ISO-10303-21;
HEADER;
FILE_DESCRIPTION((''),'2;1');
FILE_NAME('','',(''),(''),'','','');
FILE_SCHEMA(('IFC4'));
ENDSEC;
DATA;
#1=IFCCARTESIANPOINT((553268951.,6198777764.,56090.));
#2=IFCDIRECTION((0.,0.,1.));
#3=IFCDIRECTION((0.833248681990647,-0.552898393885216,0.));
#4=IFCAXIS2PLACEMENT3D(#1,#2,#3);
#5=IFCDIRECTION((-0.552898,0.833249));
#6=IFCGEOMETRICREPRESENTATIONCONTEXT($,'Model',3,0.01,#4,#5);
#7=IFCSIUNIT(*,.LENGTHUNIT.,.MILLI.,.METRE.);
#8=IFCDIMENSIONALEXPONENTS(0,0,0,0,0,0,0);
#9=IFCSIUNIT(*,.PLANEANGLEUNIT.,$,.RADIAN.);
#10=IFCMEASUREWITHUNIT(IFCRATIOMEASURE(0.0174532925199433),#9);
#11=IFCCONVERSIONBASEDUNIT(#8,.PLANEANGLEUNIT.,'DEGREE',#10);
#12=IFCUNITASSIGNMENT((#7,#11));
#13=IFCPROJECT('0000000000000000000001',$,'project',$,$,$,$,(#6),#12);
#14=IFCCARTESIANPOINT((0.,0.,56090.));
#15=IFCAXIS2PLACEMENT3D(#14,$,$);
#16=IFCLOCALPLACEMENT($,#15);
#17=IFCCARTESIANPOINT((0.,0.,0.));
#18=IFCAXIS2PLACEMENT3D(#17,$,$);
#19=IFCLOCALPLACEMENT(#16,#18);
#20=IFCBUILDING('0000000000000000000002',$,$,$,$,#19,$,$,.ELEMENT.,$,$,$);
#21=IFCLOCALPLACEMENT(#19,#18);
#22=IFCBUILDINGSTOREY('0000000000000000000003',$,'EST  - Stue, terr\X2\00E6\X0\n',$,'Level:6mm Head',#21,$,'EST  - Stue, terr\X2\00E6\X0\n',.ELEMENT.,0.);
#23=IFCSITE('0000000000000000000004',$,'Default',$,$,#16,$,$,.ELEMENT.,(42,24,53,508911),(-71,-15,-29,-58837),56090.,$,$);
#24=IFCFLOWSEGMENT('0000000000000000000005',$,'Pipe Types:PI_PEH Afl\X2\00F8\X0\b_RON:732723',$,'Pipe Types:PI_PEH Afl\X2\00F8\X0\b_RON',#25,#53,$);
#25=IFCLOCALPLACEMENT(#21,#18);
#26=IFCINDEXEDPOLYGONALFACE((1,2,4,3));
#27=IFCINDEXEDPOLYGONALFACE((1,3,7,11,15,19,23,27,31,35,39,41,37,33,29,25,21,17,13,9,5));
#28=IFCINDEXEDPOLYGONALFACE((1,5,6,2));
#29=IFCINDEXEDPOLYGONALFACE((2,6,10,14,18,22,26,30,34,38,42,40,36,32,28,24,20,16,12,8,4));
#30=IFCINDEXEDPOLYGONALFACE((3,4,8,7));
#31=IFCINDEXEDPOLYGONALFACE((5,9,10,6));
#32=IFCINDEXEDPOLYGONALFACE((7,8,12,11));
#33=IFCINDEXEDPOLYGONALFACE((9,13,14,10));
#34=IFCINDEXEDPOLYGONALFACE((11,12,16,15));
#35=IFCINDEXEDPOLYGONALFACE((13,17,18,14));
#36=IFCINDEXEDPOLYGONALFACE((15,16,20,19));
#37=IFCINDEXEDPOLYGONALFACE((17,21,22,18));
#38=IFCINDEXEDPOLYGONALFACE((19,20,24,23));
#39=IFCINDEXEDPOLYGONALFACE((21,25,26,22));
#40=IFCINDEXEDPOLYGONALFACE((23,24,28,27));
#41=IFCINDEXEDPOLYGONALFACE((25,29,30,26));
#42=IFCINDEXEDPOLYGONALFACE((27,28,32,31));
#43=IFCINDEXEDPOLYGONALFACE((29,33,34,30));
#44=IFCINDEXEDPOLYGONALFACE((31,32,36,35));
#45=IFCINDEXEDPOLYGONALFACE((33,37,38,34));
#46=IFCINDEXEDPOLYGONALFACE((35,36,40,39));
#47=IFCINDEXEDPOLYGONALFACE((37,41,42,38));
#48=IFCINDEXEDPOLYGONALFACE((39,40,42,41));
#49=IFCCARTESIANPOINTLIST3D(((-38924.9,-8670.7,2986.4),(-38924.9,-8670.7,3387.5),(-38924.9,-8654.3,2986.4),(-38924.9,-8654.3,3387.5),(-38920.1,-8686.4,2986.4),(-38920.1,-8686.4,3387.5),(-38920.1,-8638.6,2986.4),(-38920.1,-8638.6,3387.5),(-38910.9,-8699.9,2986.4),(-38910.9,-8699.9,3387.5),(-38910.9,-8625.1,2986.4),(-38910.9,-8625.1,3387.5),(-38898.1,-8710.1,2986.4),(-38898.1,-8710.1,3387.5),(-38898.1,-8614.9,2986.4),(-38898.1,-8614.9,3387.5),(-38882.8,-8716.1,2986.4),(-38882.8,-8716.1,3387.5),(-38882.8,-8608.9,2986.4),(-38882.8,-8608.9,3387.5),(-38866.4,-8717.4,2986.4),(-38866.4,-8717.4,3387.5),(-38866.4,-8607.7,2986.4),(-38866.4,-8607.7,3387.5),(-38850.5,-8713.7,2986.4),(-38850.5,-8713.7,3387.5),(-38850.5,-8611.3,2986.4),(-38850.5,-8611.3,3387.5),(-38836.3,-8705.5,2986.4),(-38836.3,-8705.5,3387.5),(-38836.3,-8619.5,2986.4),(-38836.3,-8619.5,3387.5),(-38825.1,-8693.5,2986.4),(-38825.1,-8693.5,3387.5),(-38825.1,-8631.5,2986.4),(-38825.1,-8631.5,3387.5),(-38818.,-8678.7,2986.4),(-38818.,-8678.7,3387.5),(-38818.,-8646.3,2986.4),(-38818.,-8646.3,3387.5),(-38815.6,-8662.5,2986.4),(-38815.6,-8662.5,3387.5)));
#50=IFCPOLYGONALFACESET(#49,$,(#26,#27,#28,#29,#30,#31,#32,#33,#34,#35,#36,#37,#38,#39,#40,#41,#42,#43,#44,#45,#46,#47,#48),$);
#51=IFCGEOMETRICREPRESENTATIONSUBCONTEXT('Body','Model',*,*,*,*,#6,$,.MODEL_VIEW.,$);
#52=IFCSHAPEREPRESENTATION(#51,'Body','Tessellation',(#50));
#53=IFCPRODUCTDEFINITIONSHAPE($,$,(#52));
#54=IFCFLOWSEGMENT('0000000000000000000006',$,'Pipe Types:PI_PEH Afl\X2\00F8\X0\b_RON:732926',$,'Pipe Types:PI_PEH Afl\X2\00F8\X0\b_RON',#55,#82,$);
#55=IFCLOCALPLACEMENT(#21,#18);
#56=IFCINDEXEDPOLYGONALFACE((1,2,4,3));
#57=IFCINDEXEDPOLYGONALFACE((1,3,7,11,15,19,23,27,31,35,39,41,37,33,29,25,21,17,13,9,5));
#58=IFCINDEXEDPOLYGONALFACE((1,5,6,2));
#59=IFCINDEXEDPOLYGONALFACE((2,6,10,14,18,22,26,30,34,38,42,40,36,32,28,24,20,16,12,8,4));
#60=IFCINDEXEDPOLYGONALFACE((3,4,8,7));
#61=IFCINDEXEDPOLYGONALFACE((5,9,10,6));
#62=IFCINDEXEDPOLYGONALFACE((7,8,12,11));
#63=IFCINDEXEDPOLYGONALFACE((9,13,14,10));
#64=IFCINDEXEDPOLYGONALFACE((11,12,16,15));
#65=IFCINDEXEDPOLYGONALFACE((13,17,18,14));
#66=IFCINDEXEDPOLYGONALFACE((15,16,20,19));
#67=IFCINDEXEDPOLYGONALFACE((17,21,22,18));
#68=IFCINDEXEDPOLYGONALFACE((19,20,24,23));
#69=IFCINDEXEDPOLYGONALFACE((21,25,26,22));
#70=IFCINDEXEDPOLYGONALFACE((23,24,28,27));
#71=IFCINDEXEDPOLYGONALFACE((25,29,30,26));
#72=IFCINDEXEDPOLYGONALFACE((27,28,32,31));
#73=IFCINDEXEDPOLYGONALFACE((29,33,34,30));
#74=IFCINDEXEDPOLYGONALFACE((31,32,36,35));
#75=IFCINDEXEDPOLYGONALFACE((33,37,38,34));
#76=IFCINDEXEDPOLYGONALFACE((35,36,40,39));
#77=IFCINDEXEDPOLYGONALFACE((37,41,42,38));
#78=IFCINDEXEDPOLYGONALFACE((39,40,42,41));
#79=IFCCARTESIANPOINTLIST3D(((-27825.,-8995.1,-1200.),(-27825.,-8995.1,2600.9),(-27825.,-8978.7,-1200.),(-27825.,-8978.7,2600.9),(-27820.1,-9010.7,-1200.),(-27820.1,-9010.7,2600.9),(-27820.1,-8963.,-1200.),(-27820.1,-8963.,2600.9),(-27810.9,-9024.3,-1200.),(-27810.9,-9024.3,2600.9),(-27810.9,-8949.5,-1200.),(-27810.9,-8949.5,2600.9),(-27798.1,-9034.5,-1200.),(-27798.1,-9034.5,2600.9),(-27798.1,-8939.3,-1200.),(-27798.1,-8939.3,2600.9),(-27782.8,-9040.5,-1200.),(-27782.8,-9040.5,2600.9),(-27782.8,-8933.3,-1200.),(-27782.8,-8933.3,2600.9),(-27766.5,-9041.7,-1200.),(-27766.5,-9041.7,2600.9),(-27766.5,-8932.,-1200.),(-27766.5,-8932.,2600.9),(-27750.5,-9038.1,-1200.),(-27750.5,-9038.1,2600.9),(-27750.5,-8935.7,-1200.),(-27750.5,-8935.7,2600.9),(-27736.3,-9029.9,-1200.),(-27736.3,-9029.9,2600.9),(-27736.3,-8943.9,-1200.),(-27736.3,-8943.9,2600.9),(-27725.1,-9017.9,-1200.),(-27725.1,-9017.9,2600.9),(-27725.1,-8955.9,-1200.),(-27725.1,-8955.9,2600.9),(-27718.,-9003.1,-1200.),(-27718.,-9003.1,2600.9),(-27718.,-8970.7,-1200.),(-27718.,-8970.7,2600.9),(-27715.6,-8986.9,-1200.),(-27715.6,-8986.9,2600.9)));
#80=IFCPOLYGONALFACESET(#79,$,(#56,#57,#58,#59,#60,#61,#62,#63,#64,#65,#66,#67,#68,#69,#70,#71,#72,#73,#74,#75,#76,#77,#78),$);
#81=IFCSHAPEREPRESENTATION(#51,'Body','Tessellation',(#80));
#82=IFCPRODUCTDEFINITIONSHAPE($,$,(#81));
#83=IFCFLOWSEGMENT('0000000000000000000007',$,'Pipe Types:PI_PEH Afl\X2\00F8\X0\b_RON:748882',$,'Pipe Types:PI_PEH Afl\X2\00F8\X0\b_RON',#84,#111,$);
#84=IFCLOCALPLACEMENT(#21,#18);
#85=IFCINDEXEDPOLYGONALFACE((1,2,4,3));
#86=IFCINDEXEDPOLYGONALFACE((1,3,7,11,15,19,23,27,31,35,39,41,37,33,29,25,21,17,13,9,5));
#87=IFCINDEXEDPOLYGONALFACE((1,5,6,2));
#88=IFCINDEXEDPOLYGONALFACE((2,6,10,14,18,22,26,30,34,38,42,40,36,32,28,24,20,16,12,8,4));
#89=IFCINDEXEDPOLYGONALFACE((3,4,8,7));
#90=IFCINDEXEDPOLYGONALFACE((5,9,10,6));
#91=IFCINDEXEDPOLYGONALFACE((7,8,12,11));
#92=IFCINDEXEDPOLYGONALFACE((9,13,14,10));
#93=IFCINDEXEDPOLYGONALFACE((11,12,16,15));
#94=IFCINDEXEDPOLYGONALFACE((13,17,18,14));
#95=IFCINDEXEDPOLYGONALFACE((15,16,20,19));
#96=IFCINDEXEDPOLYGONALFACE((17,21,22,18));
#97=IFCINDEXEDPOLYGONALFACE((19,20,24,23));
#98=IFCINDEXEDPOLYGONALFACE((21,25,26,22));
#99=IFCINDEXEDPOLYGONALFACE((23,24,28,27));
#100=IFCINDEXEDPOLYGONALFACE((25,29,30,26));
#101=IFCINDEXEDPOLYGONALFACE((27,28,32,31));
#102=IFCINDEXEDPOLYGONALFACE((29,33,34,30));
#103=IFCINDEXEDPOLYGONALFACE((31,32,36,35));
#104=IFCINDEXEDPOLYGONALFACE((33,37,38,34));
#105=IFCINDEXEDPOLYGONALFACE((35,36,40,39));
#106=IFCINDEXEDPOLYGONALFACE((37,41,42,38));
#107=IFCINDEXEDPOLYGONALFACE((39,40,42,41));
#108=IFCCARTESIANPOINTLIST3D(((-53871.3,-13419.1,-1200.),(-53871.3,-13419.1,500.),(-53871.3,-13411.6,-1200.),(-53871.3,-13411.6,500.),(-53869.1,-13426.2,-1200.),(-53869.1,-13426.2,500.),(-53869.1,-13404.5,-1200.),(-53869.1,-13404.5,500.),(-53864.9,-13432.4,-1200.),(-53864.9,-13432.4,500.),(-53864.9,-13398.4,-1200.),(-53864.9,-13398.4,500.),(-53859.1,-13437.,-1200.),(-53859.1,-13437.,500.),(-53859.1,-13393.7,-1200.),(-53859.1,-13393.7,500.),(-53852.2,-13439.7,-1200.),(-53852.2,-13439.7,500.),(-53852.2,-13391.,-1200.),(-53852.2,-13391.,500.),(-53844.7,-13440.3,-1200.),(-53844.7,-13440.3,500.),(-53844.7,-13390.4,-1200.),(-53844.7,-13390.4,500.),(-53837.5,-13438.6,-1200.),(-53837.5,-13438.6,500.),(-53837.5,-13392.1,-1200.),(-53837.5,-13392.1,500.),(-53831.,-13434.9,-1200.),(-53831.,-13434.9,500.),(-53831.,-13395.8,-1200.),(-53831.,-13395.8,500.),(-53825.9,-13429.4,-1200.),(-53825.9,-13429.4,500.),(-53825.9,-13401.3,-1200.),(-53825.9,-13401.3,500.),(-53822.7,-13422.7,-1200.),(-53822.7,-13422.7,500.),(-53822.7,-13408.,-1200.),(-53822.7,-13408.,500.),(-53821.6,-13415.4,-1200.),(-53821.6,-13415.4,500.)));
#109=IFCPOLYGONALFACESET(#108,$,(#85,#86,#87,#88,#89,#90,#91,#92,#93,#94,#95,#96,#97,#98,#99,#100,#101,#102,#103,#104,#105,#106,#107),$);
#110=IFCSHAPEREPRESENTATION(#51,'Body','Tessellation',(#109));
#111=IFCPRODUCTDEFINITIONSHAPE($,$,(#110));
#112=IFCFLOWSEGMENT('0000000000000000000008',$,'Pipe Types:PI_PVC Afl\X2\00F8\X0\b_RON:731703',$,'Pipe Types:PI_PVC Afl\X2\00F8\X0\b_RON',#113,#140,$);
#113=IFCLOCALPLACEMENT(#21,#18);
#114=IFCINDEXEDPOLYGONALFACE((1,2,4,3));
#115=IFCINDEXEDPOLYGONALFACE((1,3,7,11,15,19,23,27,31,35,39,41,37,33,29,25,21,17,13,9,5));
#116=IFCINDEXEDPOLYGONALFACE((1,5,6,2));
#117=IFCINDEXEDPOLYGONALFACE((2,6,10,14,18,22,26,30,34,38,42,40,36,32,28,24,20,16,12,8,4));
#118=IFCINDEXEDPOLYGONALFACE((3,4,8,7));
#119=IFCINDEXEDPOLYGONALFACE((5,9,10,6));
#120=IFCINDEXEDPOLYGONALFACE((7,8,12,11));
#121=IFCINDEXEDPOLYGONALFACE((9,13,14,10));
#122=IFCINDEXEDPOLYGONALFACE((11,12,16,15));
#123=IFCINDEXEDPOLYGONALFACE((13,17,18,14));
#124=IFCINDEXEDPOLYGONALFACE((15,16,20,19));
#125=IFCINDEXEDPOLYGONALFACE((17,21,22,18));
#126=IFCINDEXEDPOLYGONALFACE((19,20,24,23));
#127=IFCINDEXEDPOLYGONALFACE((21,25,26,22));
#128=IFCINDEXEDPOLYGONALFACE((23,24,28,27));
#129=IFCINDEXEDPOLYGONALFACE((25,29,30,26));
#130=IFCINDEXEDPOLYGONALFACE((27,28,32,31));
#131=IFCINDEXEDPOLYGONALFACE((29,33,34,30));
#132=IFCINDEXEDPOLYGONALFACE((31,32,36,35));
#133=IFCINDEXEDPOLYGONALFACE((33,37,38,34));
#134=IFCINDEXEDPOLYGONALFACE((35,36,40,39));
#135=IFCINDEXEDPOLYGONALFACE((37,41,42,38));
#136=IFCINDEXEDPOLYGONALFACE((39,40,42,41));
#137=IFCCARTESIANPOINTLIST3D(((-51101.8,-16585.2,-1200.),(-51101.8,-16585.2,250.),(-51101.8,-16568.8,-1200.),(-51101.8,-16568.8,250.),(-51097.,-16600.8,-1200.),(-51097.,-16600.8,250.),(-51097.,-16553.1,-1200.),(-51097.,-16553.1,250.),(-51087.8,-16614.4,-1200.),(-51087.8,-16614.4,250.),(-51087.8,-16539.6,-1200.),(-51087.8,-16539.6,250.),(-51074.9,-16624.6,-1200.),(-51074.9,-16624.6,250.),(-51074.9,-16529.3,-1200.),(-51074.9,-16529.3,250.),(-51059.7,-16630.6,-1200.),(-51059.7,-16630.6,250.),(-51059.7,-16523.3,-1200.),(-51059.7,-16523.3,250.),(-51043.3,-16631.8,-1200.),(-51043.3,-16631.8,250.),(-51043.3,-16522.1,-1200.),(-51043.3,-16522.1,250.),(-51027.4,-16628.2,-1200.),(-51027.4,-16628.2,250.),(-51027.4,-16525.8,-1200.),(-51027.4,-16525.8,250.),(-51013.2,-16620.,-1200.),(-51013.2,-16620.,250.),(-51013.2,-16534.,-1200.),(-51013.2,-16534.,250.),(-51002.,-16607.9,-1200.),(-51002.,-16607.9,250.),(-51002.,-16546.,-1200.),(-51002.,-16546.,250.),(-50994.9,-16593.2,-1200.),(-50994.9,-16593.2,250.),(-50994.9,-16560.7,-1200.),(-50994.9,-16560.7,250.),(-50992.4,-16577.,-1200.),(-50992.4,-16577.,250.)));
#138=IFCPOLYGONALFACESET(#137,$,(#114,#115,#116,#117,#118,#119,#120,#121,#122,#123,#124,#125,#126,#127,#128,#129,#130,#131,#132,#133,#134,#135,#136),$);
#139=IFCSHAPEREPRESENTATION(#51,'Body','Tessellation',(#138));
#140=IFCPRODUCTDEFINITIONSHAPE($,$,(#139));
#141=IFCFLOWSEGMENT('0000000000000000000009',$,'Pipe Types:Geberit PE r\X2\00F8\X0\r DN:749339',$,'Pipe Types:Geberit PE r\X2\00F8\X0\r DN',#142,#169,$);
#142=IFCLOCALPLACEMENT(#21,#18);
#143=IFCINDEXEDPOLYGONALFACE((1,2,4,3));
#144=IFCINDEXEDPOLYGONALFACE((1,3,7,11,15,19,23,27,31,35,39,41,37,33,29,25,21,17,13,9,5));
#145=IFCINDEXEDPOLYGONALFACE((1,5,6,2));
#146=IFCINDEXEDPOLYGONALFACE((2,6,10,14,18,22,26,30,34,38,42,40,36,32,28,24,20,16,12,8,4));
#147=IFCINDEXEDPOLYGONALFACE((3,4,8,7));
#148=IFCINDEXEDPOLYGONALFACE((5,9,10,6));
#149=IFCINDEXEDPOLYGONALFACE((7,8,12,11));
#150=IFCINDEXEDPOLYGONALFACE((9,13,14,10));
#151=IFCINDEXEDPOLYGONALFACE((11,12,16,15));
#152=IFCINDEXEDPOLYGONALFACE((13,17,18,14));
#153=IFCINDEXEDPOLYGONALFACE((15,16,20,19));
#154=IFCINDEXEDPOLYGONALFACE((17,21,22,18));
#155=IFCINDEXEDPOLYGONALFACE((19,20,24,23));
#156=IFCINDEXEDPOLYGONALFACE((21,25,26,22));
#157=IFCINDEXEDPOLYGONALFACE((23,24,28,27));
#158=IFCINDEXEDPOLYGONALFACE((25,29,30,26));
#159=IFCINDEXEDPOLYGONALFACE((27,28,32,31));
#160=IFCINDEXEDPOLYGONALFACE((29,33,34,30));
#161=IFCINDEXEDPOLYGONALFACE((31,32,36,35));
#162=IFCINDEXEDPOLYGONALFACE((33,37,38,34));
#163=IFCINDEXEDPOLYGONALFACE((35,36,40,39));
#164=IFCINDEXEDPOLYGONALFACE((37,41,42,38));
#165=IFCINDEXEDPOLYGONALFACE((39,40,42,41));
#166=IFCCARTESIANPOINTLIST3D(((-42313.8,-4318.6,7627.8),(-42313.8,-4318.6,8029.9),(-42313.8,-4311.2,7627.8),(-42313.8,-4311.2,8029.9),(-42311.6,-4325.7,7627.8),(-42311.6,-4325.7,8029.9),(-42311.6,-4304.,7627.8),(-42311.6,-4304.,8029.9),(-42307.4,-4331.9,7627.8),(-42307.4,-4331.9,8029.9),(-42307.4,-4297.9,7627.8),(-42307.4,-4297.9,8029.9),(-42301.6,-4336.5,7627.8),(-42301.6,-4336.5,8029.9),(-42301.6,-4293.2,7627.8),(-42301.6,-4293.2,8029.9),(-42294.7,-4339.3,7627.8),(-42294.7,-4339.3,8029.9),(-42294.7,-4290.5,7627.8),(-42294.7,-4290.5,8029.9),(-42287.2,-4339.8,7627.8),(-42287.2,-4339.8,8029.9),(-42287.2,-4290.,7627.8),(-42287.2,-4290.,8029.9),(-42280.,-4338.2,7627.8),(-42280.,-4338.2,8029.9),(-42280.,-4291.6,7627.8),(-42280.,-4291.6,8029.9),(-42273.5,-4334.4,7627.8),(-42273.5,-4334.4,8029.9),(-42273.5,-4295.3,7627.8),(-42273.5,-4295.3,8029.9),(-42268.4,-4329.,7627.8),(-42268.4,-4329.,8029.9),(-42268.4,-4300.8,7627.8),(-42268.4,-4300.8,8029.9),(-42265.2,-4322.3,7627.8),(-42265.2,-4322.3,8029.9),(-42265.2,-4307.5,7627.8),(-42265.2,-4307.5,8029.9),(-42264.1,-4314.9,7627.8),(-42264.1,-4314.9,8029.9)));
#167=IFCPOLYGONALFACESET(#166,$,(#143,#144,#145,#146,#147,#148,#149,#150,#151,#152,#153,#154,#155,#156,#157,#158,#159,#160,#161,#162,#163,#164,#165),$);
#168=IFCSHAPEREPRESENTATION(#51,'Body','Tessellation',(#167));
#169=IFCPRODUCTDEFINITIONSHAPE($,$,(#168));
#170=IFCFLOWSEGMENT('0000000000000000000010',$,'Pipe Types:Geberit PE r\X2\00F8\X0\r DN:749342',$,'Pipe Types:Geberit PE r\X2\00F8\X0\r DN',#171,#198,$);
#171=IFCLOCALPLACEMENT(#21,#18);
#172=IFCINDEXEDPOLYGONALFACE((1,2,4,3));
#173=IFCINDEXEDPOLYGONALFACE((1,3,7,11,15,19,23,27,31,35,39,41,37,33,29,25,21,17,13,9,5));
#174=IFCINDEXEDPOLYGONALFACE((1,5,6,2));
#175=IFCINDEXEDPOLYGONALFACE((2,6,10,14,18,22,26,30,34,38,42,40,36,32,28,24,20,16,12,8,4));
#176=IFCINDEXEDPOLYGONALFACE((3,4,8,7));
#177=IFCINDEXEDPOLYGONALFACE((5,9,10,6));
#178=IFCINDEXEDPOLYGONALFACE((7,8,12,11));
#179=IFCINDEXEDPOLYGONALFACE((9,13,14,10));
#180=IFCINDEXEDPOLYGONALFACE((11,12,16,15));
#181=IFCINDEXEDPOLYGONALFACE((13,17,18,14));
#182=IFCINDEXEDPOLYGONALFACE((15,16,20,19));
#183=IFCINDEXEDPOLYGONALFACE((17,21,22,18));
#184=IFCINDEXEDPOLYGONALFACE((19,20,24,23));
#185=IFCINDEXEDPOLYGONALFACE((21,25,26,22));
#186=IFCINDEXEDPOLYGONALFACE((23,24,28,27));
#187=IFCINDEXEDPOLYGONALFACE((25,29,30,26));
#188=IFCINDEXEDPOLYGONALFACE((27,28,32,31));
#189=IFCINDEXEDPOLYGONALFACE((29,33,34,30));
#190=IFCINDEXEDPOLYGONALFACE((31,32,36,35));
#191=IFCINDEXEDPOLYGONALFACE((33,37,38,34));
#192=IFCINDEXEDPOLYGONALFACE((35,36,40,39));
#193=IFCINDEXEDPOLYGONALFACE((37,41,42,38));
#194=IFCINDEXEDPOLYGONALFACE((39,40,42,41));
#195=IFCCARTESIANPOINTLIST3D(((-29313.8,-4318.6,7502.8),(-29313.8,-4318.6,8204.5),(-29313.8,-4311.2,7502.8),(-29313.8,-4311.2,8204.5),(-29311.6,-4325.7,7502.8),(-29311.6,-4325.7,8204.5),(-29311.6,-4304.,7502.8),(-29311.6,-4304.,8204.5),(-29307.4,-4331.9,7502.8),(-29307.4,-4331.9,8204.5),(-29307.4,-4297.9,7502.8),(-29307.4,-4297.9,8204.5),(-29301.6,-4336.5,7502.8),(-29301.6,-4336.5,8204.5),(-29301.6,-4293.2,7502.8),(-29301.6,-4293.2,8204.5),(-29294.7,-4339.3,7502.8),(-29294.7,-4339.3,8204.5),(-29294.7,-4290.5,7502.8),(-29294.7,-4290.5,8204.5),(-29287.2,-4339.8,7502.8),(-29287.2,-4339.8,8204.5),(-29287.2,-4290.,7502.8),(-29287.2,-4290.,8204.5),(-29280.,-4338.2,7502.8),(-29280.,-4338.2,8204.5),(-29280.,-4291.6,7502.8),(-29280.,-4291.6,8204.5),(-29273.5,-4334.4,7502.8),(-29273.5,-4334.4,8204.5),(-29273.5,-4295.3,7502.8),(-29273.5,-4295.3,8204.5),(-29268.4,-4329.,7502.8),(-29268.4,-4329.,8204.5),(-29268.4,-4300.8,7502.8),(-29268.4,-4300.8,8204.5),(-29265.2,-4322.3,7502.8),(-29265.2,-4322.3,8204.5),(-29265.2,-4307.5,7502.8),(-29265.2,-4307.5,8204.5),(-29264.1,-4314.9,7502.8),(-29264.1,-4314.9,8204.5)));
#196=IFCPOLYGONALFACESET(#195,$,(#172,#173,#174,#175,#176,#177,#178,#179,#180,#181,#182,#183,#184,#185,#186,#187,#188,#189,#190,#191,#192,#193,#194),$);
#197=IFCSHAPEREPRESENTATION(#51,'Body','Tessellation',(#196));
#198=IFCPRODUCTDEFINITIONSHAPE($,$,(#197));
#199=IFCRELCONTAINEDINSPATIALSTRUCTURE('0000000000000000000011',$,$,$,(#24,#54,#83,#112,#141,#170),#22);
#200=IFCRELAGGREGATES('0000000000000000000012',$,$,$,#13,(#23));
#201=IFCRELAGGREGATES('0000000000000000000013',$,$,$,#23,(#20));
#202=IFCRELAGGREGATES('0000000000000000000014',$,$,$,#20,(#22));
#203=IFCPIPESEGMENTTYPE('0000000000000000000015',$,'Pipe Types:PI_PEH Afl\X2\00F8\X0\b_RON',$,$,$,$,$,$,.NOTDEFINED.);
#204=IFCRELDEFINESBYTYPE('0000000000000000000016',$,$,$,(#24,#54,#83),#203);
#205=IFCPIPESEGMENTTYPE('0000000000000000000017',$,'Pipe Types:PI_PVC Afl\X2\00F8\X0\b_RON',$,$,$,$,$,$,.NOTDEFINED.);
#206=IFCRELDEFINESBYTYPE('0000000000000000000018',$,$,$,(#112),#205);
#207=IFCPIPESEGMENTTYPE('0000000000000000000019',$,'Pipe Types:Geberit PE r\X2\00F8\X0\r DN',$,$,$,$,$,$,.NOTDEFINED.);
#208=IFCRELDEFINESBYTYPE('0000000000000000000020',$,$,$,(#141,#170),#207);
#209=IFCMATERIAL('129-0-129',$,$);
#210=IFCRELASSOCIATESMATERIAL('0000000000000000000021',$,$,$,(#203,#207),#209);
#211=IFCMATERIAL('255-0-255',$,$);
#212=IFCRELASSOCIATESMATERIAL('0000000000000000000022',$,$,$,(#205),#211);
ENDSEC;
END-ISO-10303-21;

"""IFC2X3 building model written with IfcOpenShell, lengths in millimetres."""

from ifc_helpers import new_model, entity, si_unit, converted_unit, direction, frame, frame_2d, origin, origin_2d_with_axis, place, context, subcontext, project, spatial, circle, extrude, material, type_object, element, save


model = new_model("IFC2X3")

# Units and contexts
model_context = context("Model", 3, precision=0.01, world=frame((553268951.0, 6198777764.0, 56090.0), z_axis=(0.0, 0.0, 1.0), x_axis=(0.833248681990647, -0.552898393885216, 0.0)), true_north=direction((-0.552898, 0.833249)))
body_context = subcontext(model_context, "Body", "Model", "MODEL_VIEW")
ifc_project = project(units=[si_unit("LENGTHUNIT", "METRE", prefix="MILLI"), converted_unit("PLANEANGLEUNIT", "DEGREE", entity("IfcRatioMeasure", 0.0174532925199433), si_unit("PLANEANGLEUNIT", "RADIAN"), dimensions=[0, 0, 0, 0, 0, 0, 0])], contexts=[model_context])

# Site, building, storey
site_placement = place(None, frame((0.0, 0.0, 56090.0)))
site = spatial("IfcSite", under=ifc_project, at=site_placement, Name="Default", CompositionType="ELEMENT", RefLatitude=(42, 24, 53, 508911), RefLongitude=(-71, -15, -29, -58837), RefElevation=56090.0)
building_placement = place(site_placement, origin())
building = spatial("IfcBuilding", under=site, at=building_placement, CompositionType="ELEMENT")
storey_placement = place(building_placement, frame((0.0, 0.0, 0.0)))
storey = spatial("IfcBuildingStorey", under=building, at=storey_placement, Name="EST  - Stue, terræn", ObjectType="Level:6mm Head", LongName="EST  - Stue, terræn", CompositionType="ELEMENT", Elevation=0.0)

# Flow segments
ifc_material_1 = material(Name="129-0-129")
pipe_segment_type_1 = type_object("IfcPipeSegmentType", Name="Pipe Types:PI_PEH Afløb_RON", PredefinedType="NOTDEFINED", material=ifc_material_1)
flow_segment_1_placement = place(storey_placement, origin())
element("IfcFlowSegment", 1, at=flow_segment_1_placement, inside=storey, type_object=pipe_segment_type_1, Name="Pipe Types:PI_PEH Afløb_RON:732723", ObjectType="Pipe Types:PI_PEH Afløb_RON", context=body_context, shape_type="SweptSolid", body=[
    extrude(circle(Radius=55.0, at=origin_2d_with_axis()), frame((-38870.6, -8662.5, 2986.4)), (0.0, 0.0, 1.0), 401.1),
])
flow_segment_2_placement = place(storey_placement, origin())
element("IfcFlowSegment", 2, at=flow_segment_2_placement, inside=storey, type_object=pipe_segment_type_1, Name="Pipe Types:PI_PEH Afløb_RON:732926", ObjectType="Pipe Types:PI_PEH Afløb_RON", context=body_context, shape_type="SweptSolid", body=[
    extrude(circle(Radius=55.0, at=origin_2d_with_axis()), frame((-27770.6, -8986.9, -1200.0)), (0.0, 0.0, 1.0), 3800.9),
])
flow_segment_3_placement = place(storey_placement, origin())
element("IfcFlowSegment", 3, at=flow_segment_3_placement, inside=storey, type_object=pipe_segment_type_1, Name="Pipe Types:PI_PEH Afløb_RON:748882", ObjectType="Pipe Types:PI_PEH Afløb_RON", context=body_context, shape_type="SweptSolid", body=[
    extrude(circle(Radius=25.0, at=frame_2d((0.0, 0.0), x_axis=(1.0, 0.0))), frame((-53846.6, -13415.4, -1200.0)), (0.0, 0.0, 1.0), 1700.0),
])
ifc_material_2 = material(Name="255-0-255")
pipe_segment_type_2 = type_object("IfcPipeSegmentType", Name="Pipe Types:PI_PVC Afløb_RON", PredefinedType="NOTDEFINED", material=ifc_material_2)
flow_segment_4_placement = place(storey_placement, origin())
element("IfcFlowSegment", 4, at=flow_segment_4_placement, inside=storey, type_object=pipe_segment_type_2, Name="Pipe Types:PI_PVC Afløb_RON:731703", ObjectType="Pipe Types:PI_PVC Afløb_RON", context=body_context, shape_type="SweptSolid", body=[
    extrude(circle(Radius=55.0, at=origin_2d_with_axis()), frame((-51047.4, -16577.0, -1200.0)), (0.0, 0.0, 1.0), 1450.0),
])
pipe_segment_type_3 = type_object("IfcPipeSegmentType", Name="Pipe Types:Geberit PE rør DN", PredefinedType="NOTDEFINED", material=ifc_material_1)
flow_segment_5_placement = place(storey_placement, origin())
element("IfcFlowSegment", 5, at=flow_segment_5_placement, inside=storey, type_object=pipe_segment_type_3, Name="Pipe Types:Geberit PE rør DN:749339", ObjectType="Pipe Types:Geberit PE rør DN", context=body_context, shape_type="SweptSolid", body=[
    extrude(circle(Radius=25.0, at=frame_2d((0.0, 0.0), x_axis=(1.0, 0.0))), frame((-42289.1, -4314.9, 7627.8)), (0.0, 0.0, 1.0), 402.1),
])
flow_segment_6_placement = place(storey_placement, origin())
element("IfcFlowSegment", 6, at=flow_segment_6_placement, inside=storey, type_object=pipe_segment_type_3, Name="Pipe Types:Geberit PE rør DN:749342", ObjectType="Pipe Types:Geberit PE rør DN", context=body_context, shape_type="SweptSolid", body=[
    extrude(circle(Radius=25.0, at=frame_2d((0.0, 0.0), x_axis=(1.0, 0.0))), frame((-29289.1, -4314.9, 7502.8)), (0.0, 0.0, 1.0), 701.7),
])

save(model, "model.ifc")
